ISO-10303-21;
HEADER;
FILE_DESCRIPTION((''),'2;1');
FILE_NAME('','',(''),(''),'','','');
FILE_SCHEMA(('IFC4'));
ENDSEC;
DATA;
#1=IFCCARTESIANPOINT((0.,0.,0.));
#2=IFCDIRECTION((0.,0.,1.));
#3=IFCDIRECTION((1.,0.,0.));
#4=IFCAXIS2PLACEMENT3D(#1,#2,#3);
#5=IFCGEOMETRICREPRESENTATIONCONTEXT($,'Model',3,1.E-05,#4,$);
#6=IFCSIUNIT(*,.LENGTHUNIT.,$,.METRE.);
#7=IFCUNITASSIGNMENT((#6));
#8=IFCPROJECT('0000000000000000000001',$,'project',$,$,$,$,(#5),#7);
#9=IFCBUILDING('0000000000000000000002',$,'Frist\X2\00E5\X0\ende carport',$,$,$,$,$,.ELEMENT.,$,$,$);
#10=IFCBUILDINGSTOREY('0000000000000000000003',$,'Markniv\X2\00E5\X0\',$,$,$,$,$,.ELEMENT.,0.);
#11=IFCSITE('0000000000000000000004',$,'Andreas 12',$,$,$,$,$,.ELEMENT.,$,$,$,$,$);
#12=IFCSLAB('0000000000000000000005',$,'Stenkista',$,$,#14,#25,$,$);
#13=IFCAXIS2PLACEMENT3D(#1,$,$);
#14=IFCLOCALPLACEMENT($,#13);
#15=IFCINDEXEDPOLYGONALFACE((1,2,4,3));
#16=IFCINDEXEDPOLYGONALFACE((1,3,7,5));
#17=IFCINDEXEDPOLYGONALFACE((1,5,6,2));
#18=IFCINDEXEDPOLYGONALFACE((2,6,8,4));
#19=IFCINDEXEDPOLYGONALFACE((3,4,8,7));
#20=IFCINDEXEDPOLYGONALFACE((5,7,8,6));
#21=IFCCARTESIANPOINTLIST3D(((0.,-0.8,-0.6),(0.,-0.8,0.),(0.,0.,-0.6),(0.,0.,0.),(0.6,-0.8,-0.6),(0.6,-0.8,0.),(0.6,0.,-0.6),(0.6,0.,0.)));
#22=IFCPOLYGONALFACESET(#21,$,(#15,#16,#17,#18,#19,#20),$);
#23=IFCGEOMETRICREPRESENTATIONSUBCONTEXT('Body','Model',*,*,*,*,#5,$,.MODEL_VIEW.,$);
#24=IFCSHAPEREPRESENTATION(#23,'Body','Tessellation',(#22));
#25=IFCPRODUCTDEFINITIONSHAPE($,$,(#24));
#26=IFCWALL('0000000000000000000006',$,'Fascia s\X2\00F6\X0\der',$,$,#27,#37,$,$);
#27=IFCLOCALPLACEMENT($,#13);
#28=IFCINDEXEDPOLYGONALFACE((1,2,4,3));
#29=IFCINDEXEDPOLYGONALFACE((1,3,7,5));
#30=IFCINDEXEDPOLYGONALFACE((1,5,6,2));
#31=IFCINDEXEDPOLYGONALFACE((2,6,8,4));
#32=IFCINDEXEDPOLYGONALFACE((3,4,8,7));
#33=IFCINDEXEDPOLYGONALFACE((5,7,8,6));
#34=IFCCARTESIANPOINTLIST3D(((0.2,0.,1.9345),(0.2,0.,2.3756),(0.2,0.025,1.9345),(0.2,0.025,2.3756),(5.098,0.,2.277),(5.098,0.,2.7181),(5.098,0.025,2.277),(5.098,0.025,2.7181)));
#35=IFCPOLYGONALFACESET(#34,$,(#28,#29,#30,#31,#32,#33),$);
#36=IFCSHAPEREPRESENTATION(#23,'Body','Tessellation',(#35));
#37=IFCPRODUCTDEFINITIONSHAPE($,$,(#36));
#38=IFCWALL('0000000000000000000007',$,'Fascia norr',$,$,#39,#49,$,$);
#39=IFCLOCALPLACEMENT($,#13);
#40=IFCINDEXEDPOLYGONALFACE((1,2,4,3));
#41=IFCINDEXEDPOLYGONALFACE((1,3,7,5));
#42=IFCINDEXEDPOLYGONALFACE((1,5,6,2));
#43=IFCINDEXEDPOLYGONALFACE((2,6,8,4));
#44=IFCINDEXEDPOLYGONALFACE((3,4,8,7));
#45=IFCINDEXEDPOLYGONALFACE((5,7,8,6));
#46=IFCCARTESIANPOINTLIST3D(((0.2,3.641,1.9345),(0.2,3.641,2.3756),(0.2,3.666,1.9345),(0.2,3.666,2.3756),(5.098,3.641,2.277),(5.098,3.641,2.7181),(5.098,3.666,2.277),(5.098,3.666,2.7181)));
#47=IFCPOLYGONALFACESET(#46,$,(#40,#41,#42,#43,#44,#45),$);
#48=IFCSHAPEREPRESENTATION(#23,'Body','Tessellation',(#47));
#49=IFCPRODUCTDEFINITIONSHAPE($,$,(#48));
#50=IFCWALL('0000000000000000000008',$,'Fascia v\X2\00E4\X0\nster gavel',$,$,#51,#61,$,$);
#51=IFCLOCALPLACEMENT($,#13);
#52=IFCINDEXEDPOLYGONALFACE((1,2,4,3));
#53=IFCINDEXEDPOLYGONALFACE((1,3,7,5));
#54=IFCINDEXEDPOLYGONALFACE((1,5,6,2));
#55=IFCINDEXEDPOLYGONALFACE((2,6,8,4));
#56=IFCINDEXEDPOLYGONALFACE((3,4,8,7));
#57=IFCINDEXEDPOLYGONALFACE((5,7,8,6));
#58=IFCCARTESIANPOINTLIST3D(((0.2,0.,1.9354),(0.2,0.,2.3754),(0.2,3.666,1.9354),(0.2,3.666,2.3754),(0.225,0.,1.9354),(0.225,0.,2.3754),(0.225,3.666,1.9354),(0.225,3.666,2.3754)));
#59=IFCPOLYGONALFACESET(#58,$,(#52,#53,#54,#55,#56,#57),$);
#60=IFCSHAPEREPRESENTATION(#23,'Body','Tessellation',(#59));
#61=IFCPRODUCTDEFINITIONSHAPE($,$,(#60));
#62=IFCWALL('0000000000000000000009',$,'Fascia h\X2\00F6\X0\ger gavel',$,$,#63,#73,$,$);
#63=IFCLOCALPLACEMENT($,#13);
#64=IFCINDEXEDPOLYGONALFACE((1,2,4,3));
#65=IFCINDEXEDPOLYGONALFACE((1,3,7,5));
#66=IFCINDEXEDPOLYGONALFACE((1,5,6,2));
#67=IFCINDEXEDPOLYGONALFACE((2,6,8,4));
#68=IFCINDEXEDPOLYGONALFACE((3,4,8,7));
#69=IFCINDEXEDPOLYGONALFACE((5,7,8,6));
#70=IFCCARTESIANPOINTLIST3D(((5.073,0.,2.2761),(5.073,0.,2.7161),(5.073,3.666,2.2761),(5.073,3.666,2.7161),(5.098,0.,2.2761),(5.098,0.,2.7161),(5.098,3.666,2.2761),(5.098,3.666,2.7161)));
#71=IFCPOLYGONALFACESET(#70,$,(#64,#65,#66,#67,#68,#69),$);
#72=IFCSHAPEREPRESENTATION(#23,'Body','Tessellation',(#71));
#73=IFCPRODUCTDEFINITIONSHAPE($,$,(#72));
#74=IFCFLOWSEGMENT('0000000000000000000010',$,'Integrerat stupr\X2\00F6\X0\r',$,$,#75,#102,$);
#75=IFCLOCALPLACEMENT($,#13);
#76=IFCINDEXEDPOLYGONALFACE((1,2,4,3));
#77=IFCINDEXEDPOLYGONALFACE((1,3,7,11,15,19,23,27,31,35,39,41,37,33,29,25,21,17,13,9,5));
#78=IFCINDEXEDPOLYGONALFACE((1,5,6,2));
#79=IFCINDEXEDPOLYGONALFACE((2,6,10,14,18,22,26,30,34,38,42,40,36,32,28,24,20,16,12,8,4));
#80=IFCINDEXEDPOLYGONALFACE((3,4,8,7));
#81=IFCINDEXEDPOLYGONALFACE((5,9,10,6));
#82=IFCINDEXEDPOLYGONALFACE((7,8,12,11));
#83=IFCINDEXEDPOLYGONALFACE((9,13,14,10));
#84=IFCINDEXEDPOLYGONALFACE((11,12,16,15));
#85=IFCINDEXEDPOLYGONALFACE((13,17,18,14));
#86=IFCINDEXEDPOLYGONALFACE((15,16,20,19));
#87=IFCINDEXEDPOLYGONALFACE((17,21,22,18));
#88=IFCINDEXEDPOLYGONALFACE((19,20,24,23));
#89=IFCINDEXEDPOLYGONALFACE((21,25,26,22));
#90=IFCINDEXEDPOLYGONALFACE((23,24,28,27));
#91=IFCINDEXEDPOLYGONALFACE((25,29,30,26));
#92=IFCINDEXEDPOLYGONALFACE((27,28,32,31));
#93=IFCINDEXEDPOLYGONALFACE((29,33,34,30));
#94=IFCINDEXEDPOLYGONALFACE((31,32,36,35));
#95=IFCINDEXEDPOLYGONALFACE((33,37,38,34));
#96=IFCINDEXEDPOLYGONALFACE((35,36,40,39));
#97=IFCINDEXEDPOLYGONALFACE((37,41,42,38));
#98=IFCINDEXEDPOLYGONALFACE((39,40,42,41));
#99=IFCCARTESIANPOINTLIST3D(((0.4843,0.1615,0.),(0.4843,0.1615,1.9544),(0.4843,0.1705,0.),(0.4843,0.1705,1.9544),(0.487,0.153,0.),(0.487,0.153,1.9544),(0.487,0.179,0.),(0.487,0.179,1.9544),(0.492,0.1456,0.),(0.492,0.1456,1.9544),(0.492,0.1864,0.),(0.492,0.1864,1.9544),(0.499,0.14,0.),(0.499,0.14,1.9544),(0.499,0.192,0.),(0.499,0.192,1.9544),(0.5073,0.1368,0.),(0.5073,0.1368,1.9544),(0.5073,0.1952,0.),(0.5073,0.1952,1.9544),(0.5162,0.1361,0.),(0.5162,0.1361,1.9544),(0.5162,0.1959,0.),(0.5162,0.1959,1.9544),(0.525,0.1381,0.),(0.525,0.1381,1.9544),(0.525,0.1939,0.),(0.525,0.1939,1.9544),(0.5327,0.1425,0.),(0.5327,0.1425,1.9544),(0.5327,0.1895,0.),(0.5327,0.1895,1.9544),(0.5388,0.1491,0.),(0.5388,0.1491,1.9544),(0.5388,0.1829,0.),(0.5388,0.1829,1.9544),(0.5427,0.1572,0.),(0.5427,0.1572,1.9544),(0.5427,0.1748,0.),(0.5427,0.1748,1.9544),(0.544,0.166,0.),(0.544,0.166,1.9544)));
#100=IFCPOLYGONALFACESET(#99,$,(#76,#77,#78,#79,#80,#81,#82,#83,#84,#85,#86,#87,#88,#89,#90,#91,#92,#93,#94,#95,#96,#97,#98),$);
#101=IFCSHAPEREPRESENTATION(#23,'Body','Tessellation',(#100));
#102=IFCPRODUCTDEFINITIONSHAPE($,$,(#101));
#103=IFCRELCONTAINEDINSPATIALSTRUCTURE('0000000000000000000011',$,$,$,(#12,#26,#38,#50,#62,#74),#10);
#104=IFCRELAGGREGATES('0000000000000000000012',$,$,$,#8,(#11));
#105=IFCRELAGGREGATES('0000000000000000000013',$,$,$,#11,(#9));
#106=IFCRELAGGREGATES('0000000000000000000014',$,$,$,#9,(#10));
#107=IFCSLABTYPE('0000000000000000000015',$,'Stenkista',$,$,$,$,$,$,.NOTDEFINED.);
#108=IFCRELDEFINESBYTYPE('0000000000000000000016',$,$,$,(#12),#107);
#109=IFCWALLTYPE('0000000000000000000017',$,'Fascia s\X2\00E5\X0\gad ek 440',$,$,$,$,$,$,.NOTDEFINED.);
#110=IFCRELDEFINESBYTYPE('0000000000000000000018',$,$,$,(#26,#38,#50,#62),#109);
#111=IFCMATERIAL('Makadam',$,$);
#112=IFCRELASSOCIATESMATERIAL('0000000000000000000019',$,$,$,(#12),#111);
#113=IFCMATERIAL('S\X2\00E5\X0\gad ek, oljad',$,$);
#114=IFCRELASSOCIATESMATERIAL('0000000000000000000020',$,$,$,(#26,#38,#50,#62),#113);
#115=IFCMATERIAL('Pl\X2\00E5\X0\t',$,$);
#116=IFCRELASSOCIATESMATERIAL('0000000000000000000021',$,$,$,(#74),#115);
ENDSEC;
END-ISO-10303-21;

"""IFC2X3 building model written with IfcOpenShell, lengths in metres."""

from ifc_helpers import new_model, si_unit, frame, frame_2d, origin, origin_with_axes, origin_2d, place, context, subcontext, project, spatial, rectangle, circle, extrude, clip, halfspace, material, type_object, element, save


model = new_model("IFC2X3")

# Units and contexts
model_context = context("Model", 3, precision=1e-05, world=origin_with_axes())
body_context = subcontext(model_context, "Body", "Model", "MODEL_VIEW")
ifc_project = project(units=[si_unit("LENGTHUNIT", "METRE")], contexts=[model_context])

# Site, building, storey
site = spatial("IfcSite", under=ifc_project, Name="Andreas 12", CompositionType="ELEMENT")
building = spatial("IfcBuilding", under=site, Name="Fristående carport", CompositionType="ELEMENT")
storey = spatial("IfcBuildingStorey", under=building, Name="Marknivå", CompositionType="ELEMENT", Elevation=0.0)

# Slab
ifc_material_1 = material(Name="Makadam")
slab_type_1 = type_object("IfcSlabType", Name="Stenkista", PredefinedType="NOTDEFINED")
slab_1_placement = place(None, frame((0.0, -0.8, -0.6), z_axis=(0.0, 0.0, 1.0), x_axis=(1.0, 0.0, 0.0)))
element("IfcSlab", 1, at=slab_1_placement, inside=storey, type_object=slab_type_1, material=ifc_material_1, Name="Stenkista", context=body_context, shape_type="SweptSolid", body=[
    extrude(rectangle(XDim=0.6, YDim=0.8, at=frame_2d((0.3, 0.4))), origin(), (0.0, 0.0, 1.0), 0.6),
])

# Walls
ifc_material_2 = material(Name="Sågad ek, oljad")
wall_type = type_object("IfcWallType", Name="Fascia sågad ek 440", PredefinedType="NOTDEFINED")
for number, where, z_axis, x_axis, name in (
    (2, (0.2, 0.0, 1.9345), (0.0, 0.0, 1.0), (1.0, 0.0, 0.0), "Fascia söder"),
    (3, (0.2, 3.641, 1.9345), (0.0, 0.0, 1.0), (1.0, 0.0, 0.0), "Fascia norr"),
):
    element("IfcWall", number, at=place(None, frame(where, z_axis=z_axis, x_axis=x_axis)), inside=storey, type_object=wall_type, material=ifc_material_2, Name=name, context=body_context, shape_type="Clipping", body=[
        clip(clip(extrude(rectangle(XDim=4.898, YDim=0.025, at=frame_2d((2.449, 0.0125))), origin(), (0.0, 0.0, 1.0), 0.8325), halfspace(frame((0.0, 0.0, 0.0), z_axis=(-0.069756, 0.0, 0.997564), x_axis=(0.997564, 0.0, 0.069756)), True)), halfspace(frame((0.0, 0.0, 0.4411), z_axis=(-0.069756, 0.0, 0.997564), x_axis=(0.997564, 0.0, 0.069756)), False)),
    ])
for number, where, z_axis, x_axis, name in (
    (4, (0.2, 0.0, 1.9354), (0.0, 0.0, 1.0), (1.0, 0.0, 0.0), "Fascia vänster gavel"),
    (5, (5.073, 0.0, 2.2761), (0.0, 0.0, 1.0), (1.0, 0.0, 0.0), "Fascia höger gavel"),
):
    element("IfcWall", number, at=place(None, frame(where, z_axis=z_axis, x_axis=x_axis)), inside=storey, type_object=wall_type, material=ifc_material_2, Name=name, context=body_context, shape_type="SweptSolid", body=[
        extrude(rectangle(XDim=0.025, YDim=3.666, at=frame_2d((0.0125, 1.833))), origin(), (0.0, 0.0, 1.0), 0.44),
    ])

# Flow segment
ifc_material_3 = material(Name="Plåt")
flow_segment_placement = place(None, frame((0.514, 0.166, 0.0), z_axis=(0.0, 0.0, 1.0), x_axis=(1.0, 0.0, 0.0)))
element("IfcFlowSegment", 6, at=flow_segment_placement, inside=storey, material=ifc_material_3, Name="Integrerat stuprör", context=body_context, shape_type="SweptSolid", body=[
    extrude(circle(Radius=0.03, at=origin_2d()), origin(), (0.0, 0.0, 1.0), 1.9544),
])

save(model, "model.ifc")
